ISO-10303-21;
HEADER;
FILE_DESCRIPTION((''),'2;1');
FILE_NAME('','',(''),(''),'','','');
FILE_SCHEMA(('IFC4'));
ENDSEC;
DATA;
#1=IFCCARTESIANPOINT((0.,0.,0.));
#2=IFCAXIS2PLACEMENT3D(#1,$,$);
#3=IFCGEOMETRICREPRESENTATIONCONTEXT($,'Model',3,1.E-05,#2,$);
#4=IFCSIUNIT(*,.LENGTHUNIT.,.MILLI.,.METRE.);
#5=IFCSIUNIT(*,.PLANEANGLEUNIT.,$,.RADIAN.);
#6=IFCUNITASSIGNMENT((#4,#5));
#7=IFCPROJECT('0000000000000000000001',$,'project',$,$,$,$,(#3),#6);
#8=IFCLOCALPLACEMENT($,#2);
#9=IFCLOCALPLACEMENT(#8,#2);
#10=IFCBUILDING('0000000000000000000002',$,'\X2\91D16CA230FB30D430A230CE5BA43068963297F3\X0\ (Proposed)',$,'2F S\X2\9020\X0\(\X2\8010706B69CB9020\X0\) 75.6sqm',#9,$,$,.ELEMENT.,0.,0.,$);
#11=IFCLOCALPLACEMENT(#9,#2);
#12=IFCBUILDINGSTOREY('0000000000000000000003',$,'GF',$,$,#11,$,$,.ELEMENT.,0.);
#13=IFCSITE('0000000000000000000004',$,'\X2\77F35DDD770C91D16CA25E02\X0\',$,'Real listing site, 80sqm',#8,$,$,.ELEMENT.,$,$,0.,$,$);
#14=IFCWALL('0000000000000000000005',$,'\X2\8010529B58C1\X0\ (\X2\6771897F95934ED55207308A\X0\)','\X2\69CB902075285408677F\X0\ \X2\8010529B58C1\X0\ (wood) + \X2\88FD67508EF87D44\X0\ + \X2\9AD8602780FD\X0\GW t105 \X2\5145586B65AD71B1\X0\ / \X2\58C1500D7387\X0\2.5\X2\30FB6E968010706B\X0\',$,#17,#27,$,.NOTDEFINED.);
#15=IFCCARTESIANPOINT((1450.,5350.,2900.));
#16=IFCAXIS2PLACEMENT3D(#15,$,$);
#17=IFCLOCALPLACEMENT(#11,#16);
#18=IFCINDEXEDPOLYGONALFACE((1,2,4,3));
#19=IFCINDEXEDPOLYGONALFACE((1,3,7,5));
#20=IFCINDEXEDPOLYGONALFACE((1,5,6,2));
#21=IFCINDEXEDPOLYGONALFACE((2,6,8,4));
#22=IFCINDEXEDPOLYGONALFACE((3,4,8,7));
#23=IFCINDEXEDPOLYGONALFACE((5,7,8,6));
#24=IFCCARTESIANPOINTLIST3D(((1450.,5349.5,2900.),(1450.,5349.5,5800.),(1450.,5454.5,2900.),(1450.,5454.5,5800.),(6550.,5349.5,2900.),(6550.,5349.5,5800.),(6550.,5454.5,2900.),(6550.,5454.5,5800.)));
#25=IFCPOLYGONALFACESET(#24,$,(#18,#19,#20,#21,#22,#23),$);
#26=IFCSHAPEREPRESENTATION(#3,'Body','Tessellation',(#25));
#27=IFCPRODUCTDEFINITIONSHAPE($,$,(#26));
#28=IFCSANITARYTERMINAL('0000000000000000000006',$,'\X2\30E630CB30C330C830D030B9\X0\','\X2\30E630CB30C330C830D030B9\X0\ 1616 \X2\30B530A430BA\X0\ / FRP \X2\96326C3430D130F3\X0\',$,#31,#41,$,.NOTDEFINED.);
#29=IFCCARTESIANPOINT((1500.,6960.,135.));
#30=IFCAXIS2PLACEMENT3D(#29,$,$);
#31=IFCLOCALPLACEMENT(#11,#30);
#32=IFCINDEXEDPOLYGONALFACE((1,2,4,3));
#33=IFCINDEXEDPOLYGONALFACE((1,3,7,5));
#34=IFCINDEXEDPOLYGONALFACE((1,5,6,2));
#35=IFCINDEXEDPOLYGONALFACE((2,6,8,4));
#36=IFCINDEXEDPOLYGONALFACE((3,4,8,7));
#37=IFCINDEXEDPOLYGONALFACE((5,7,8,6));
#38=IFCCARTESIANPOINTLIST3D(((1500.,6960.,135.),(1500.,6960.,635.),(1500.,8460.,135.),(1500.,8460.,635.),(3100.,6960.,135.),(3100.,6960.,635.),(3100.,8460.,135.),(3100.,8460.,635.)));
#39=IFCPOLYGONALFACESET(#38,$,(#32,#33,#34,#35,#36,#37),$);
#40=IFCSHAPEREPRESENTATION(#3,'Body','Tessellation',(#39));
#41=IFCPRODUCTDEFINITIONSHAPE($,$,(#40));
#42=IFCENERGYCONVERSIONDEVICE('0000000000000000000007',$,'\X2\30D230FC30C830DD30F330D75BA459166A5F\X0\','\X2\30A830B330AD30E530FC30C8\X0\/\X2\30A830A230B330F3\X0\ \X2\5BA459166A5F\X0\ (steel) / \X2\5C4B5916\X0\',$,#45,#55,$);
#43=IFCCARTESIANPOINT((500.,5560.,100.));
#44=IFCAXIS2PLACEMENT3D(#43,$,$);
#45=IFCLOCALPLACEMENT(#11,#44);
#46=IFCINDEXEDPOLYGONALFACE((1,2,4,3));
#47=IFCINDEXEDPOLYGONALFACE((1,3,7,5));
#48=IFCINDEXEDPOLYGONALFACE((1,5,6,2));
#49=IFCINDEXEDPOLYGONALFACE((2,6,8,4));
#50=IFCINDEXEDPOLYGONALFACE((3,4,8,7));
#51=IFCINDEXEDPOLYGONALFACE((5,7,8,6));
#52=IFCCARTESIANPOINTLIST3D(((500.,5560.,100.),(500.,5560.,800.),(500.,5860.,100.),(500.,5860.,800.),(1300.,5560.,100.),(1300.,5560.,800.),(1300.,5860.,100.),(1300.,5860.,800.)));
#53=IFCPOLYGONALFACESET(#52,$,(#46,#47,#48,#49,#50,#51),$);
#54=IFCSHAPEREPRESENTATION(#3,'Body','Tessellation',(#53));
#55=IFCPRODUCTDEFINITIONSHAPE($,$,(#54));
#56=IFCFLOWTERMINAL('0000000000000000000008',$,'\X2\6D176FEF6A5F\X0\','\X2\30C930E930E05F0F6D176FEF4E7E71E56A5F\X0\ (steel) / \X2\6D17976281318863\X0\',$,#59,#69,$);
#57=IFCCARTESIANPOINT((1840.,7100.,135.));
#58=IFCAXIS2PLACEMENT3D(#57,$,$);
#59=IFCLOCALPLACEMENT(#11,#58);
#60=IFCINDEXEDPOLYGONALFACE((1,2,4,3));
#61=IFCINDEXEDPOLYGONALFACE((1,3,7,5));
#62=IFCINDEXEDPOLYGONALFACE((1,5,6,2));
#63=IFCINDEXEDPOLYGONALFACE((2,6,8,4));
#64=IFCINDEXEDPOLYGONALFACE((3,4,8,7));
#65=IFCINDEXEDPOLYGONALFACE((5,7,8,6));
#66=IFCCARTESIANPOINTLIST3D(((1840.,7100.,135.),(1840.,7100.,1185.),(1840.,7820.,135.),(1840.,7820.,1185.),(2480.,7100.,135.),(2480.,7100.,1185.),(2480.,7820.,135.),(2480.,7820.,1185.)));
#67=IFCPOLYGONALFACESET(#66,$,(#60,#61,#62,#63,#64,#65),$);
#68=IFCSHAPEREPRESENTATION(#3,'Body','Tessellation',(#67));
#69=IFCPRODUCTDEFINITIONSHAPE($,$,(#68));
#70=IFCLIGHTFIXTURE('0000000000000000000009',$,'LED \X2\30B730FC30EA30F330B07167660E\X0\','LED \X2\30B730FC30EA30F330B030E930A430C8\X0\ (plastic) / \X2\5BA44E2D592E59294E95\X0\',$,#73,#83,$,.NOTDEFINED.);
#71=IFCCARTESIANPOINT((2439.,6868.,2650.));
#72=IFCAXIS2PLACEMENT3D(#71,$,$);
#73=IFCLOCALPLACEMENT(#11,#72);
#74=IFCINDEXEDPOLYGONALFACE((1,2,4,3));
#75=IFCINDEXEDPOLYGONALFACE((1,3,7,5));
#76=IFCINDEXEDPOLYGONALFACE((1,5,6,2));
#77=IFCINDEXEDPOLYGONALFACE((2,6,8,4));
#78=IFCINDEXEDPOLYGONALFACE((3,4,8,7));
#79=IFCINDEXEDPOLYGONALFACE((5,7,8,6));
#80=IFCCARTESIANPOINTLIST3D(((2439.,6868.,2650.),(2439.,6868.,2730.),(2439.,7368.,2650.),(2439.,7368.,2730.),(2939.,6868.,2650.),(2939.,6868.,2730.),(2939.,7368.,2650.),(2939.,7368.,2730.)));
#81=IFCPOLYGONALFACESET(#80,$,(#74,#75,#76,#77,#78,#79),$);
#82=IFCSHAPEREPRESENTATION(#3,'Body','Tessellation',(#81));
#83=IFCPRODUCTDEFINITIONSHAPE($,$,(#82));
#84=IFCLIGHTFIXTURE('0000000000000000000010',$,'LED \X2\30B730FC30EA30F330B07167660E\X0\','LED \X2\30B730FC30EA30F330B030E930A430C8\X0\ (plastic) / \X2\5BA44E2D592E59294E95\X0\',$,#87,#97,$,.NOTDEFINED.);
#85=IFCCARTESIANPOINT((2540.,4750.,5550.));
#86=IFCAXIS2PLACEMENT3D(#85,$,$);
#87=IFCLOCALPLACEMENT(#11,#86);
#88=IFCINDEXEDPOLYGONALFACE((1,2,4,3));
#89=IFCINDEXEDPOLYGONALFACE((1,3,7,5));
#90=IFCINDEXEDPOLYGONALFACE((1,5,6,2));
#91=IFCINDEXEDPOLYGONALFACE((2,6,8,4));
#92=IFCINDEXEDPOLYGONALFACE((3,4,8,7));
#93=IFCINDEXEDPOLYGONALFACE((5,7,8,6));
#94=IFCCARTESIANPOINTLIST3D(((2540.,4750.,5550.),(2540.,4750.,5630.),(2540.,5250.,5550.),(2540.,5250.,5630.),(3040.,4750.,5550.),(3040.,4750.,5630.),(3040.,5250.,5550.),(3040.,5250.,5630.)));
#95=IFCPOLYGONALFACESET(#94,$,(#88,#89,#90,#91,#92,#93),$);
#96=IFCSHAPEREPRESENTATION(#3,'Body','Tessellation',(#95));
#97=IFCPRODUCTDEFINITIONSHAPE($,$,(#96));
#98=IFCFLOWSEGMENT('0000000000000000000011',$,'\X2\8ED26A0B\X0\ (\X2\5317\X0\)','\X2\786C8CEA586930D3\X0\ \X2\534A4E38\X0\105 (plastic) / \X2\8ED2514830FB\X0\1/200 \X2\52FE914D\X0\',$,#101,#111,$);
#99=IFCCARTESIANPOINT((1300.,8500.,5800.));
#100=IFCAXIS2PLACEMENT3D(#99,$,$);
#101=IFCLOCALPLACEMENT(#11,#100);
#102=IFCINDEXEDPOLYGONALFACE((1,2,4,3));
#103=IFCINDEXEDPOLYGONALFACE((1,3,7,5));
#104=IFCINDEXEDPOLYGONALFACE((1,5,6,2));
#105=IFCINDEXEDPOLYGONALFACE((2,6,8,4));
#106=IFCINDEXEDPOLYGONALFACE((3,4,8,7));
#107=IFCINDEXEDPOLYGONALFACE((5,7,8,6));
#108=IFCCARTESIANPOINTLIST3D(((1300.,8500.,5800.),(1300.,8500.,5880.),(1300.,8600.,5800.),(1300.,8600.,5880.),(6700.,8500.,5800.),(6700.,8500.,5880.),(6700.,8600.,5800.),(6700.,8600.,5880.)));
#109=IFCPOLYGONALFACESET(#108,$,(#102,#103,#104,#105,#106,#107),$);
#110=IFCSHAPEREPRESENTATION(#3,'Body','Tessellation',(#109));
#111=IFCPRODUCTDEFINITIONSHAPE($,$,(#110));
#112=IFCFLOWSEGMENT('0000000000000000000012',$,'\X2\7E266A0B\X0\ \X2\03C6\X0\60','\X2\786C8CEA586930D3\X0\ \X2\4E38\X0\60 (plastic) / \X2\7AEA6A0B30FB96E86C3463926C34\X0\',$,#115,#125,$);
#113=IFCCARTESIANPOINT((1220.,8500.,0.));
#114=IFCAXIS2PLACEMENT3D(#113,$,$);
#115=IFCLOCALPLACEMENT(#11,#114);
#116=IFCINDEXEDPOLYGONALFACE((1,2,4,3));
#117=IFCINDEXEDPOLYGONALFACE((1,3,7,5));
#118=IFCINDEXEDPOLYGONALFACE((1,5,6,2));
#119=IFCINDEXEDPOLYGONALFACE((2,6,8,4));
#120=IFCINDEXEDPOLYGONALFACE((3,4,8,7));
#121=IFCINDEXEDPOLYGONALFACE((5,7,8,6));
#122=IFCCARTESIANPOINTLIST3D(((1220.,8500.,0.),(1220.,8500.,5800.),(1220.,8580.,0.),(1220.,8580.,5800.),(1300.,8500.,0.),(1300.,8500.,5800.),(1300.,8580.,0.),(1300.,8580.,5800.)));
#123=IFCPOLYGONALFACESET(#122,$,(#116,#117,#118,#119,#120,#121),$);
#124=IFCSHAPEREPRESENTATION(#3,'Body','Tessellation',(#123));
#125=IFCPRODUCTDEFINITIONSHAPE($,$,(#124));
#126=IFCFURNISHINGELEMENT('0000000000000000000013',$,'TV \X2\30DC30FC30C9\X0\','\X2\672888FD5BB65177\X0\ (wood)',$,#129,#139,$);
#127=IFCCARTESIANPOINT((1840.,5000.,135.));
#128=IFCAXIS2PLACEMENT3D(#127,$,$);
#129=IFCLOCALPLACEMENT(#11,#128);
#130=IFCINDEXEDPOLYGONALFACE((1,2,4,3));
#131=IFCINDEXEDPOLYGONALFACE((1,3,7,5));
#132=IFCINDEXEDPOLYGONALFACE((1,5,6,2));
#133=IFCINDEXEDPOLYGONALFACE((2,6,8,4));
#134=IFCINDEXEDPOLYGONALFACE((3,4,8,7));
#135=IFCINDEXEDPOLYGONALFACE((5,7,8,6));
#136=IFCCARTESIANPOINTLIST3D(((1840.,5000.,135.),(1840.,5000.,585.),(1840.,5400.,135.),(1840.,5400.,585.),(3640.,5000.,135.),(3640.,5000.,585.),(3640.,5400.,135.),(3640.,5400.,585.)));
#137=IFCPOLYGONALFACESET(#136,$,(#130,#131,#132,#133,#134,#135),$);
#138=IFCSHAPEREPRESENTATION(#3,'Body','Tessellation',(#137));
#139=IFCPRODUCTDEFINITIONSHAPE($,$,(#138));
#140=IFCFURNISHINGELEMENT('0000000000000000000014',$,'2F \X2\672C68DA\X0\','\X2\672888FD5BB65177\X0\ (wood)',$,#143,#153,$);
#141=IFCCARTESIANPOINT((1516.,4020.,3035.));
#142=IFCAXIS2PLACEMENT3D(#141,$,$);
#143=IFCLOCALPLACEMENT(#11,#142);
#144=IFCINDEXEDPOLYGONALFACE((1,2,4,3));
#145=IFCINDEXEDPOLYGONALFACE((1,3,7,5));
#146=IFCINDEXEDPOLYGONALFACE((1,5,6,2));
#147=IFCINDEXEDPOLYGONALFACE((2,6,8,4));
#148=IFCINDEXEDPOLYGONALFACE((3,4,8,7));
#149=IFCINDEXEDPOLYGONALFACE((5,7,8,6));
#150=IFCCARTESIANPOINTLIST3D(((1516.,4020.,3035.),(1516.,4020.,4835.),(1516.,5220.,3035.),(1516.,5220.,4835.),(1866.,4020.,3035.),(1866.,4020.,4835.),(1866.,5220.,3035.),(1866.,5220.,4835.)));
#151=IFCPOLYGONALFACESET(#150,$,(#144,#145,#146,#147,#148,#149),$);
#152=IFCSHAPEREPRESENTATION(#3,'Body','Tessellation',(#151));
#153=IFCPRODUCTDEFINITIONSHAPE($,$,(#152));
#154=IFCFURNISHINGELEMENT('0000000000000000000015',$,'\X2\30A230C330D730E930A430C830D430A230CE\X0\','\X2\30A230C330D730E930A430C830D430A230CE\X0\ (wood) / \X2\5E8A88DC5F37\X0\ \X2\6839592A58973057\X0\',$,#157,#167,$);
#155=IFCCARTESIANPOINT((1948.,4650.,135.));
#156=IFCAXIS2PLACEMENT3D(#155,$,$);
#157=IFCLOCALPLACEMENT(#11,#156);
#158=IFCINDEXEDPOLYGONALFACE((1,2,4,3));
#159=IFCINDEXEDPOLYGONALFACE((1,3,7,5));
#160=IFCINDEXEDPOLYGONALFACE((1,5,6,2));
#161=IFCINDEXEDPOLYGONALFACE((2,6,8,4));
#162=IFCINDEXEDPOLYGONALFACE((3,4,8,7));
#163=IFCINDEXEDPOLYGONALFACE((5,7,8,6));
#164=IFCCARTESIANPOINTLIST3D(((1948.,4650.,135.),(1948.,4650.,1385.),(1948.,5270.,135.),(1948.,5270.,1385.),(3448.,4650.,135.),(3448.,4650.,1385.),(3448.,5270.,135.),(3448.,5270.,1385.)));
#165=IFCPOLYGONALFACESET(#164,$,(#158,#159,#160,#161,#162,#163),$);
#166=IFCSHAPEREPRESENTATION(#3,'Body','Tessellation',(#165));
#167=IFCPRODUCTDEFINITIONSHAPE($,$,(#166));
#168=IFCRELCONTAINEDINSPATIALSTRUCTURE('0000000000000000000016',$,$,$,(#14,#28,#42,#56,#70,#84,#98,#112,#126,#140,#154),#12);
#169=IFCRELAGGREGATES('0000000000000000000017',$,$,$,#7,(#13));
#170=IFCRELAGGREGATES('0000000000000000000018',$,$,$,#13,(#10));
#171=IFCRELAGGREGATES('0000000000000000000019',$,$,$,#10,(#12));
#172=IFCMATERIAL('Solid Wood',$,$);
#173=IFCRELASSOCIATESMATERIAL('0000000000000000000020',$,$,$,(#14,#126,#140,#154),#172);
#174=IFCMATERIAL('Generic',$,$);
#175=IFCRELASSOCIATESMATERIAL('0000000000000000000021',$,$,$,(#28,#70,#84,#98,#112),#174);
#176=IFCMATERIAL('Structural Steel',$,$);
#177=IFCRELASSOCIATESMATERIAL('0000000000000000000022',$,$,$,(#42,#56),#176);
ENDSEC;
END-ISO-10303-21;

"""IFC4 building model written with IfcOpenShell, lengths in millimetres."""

from ifc_helpers import new_model, si_unit, frame, frame_2d, origin, place, context, project, spatial, rectangle, extrude, material, element, save


model = new_model("IFC4")

# Units and contexts
model_context = context("Model", 3, precision=1e-05, world=origin())
ifc_project = project(units=[si_unit("LENGTHUNIT", "METRE", prefix="MILLI"), si_unit("PLANEANGLEUNIT", "RADIAN")], contexts=[model_context])

# Site, building, storey
site_placement = place(None, origin())
site = spatial("IfcSite", under=ifc_project, at=site_placement, Name="石川県金沢市", ObjectType="Real listing site, 80sqm", CompositionType="ELEMENT", RefElevation=0.0)
building_placement = place(site_placement, origin())
building = spatial("IfcBuilding", under=site, at=building_placement, Name="金沢・ピアノ室と防音 (Proposed)", ObjectType="2F S造(耐火構造) 75.6sqm", CompositionType="ELEMENT", ElevationOfRefHeight=0.0, ElevationOfTerrain=0.0)
storey_placement = place(building_placement, origin())
storey = spatial("IfcBuildingStorey", under=building, at=storey_placement, Name="GF", CompositionType="ELEMENT", Elevation=0.0)

# Shared definitions
ifc_material_1 = material(Name="Solid Wood")

# Wall
wall_1_placement = place(storey_placement, frame((1450.0, 5350.0, 2900.0)))
element("IfcWall", 1, at=wall_1_placement, inside=storey, material=ifc_material_1, Name="耐力壁 (東西間仕切り)", Description="構造用合板 耐力壁 (wood) + 製材軸組 + 高性能GW t105 充填断熱 / 壁倍率2.5・準耐火", PredefinedType="NOTDEFINED", context=model_context, shape_type="SweptSolid", body=[
    extrude(rectangle(XDim=5100.0, YDim=105.0, at=frame_2d((2550.0, 52.0))), frame((1450.0, 5350.0, 2900.0)), (0.0, 0.0, 1.0), 2900.0),
])

# Sanitary terminal
ifc_material_2 = material(Name="Generic")
sanitary_terminal_placement = place(storey_placement, frame((1500.0, 6960.0, 135.0)))
element("IfcSanitaryTerminal", 2, at=sanitary_terminal_placement, inside=storey, material=ifc_material_2, Name="ユニットバス", Description="ユニットバス 1616 サイズ / FRP 防水パン", PredefinedType="NOTDEFINED", context=model_context, shape_type="SweptSolid", body=[
    extrude(rectangle(XDim=1600.0, YDim=1500.0, at=frame_2d((800.0, 750.0))), frame((1500.0, 6960.0, 135.0)), (0.0, 0.0, 1.0), 500.0),
])

# Shared definitions
ifc_material_3 = material(Name="Structural Steel")

# Energy conversion device
energy_conversion_device_placement = place(storey_placement, frame((500.0, 5560.0, 100.0)))
element("IfcEnergyConversionDevice", 3, at=energy_conversion_device_placement, inside=storey, material=ifc_material_3, Name="ヒートポンプ室外機", Description="エコキュート/エアコン 室外機 (steel) / 屋外", context=model_context, shape_type="SweptSolid", body=[
    extrude(rectangle(XDim=800.0, YDim=300.0, at=frame_2d((400.0, 150.0))), frame((500.0, 5560.0, 100.0)), (0.0, 0.0, 1.0), 700.0),
])

# Flow terminal
flow_terminal_placement = place(storey_placement, frame((1840.0, 7100.0, 135.0)))
element("IfcFlowTerminal", 4, at=flow_terminal_placement, inside=storey, material=ifc_material_3, Name="洗濯機", Description="ドラム式洗濯乾燥機 (steel) / 洗面脱衣", context=model_context, shape_type="SweptSolid", body=[
    extrude(rectangle(XDim=640.0, YDim=720.0, at=frame_2d((320.0, 360.0))), frame((1840.0, 7100.0, 135.0)), (0.0, 0.0, 1.0), 1050.0),
])

# Light fixtures
light_fixture_1_placement = place(storey_placement, frame((2439.0, 6868.0, 2650.0)))
element("IfcLightFixture", 5, at=light_fixture_1_placement, inside=storey, material=ifc_material_2, Name="LED シーリング照明", Description="LED シーリングライト (plastic) / 室中央天井", PredefinedType="NOTDEFINED", context=model_context, shape_type="SweptSolid", body=[
    extrude(rectangle(XDim=500.0, YDim=500.0, at=frame_2d((250.0, 250.0))), frame((2439.0, 6868.0, 2650.0)), (0.0, 0.0, 1.0), 80.0),
])
light_fixture_2_placement = place(storey_placement, frame((2540.0, 4750.0, 5550.0)))
element("IfcLightFixture", 6, at=light_fixture_2_placement, inside=storey, material=ifc_material_2, Name="LED シーリング照明", Description="LED シーリングライト (plastic) / 室中央天井", PredefinedType="NOTDEFINED", context=model_context, shape_type="SweptSolid", body=[
    extrude(rectangle(XDim=500.0, YDim=500.0, at=frame_2d((250.0, 250.0))), frame((2540.0, 4750.0, 5550.0)), (0.0, 0.0, 1.0), 80.0),
])

# Flow segments
flow_segment_1_placement = place(storey_placement, frame((1300.0, 8500.0, 5800.0)))
element("IfcFlowSegment", 7, at=flow_segment_1_placement, inside=storey, material=ifc_material_2, Name="軒樋 (北)", Description="硬質塩ビ 半丸105 (plastic) / 軒先・1/200 勾配", context=model_context, shape_type="SweptSolid", body=[
    extrude(rectangle(XDim=5400.0, YDim=100.0, at=frame_2d((2700.0, 50.0))), frame((1300.0, 8500.0, 5800.0)), (0.0, 0.0, 1.0), 80.0),
])
flow_segment_2_placement = place(storey_placement, frame((1220.0, 8500.0, 0.0)))
element("IfcFlowSegment", 8, at=flow_segment_2_placement, inside=storey, material=ifc_material_2, Name="縦樋 φ60", Description="硬質塩ビ 丸60 (plastic) / 竪樋・雨水排水", context=model_context, shape_type="SweptSolid", body=[
    extrude(rectangle(XDim=80.0, YDim=80.0, at=frame_2d((40.0, 40.0))), frame((1220.0, 8500.0, 0.0)), (0.0, 0.0, 1.0), 5800.0),
])

# Furnishing elements
furnishing_1_placement = place(storey_placement, frame((1840.0, 5000.0, 135.0)))
element("IfcFurnishingElement", 9, at=furnishing_1_placement, inside=storey, material=ifc_material_1, Name="TV ボード", Description="木製家具 (wood)", context=model_context, shape_type="SweptSolid", body=[
    extrude(rectangle(XDim=1800.0, YDim=400.0, at=frame_2d((900.0, 200.0))), frame((1840.0, 5000.0, 135.0)), (0.0, 0.0, 1.0), 450.0),
])
furnishing_2_placement = place(storey_placement, frame((1516.0, 4020.0, 3035.0)))
element("IfcFurnishingElement", 10, at=furnishing_2_placement, inside=storey, material=ifc_material_1, Name="2F 本棚", Description="木製家具 (wood)", context=model_context, shape_type="SweptSolid", body=[
    extrude(rectangle(XDim=350.0, YDim=1200.0, at=frame_2d((175.0, 600.0))), frame((1516.0, 4020.0, 3035.0)), (0.0, 0.0, 1.0), 1800.0),
])
furnishing_3_placement = place(storey_placement, frame((1948.0, 4650.0, 135.0)))
element("IfcFurnishingElement", 11, at=furnishing_3_placement, inside=storey, material=ifc_material_1, Name="アップライトピアノ", Description="アップライトピアノ (wood) / 床補強 根太増し", context=model_context, shape_type="SweptSolid", body=[
    extrude(rectangle(XDim=1500.0, YDim=620.0, at=frame_2d((750.0, 310.0))), frame((1948.0, 4650.0, 135.0)), (0.0, 0.0, 1.0), 1250.0),
])

save(model, "model.ifc")
